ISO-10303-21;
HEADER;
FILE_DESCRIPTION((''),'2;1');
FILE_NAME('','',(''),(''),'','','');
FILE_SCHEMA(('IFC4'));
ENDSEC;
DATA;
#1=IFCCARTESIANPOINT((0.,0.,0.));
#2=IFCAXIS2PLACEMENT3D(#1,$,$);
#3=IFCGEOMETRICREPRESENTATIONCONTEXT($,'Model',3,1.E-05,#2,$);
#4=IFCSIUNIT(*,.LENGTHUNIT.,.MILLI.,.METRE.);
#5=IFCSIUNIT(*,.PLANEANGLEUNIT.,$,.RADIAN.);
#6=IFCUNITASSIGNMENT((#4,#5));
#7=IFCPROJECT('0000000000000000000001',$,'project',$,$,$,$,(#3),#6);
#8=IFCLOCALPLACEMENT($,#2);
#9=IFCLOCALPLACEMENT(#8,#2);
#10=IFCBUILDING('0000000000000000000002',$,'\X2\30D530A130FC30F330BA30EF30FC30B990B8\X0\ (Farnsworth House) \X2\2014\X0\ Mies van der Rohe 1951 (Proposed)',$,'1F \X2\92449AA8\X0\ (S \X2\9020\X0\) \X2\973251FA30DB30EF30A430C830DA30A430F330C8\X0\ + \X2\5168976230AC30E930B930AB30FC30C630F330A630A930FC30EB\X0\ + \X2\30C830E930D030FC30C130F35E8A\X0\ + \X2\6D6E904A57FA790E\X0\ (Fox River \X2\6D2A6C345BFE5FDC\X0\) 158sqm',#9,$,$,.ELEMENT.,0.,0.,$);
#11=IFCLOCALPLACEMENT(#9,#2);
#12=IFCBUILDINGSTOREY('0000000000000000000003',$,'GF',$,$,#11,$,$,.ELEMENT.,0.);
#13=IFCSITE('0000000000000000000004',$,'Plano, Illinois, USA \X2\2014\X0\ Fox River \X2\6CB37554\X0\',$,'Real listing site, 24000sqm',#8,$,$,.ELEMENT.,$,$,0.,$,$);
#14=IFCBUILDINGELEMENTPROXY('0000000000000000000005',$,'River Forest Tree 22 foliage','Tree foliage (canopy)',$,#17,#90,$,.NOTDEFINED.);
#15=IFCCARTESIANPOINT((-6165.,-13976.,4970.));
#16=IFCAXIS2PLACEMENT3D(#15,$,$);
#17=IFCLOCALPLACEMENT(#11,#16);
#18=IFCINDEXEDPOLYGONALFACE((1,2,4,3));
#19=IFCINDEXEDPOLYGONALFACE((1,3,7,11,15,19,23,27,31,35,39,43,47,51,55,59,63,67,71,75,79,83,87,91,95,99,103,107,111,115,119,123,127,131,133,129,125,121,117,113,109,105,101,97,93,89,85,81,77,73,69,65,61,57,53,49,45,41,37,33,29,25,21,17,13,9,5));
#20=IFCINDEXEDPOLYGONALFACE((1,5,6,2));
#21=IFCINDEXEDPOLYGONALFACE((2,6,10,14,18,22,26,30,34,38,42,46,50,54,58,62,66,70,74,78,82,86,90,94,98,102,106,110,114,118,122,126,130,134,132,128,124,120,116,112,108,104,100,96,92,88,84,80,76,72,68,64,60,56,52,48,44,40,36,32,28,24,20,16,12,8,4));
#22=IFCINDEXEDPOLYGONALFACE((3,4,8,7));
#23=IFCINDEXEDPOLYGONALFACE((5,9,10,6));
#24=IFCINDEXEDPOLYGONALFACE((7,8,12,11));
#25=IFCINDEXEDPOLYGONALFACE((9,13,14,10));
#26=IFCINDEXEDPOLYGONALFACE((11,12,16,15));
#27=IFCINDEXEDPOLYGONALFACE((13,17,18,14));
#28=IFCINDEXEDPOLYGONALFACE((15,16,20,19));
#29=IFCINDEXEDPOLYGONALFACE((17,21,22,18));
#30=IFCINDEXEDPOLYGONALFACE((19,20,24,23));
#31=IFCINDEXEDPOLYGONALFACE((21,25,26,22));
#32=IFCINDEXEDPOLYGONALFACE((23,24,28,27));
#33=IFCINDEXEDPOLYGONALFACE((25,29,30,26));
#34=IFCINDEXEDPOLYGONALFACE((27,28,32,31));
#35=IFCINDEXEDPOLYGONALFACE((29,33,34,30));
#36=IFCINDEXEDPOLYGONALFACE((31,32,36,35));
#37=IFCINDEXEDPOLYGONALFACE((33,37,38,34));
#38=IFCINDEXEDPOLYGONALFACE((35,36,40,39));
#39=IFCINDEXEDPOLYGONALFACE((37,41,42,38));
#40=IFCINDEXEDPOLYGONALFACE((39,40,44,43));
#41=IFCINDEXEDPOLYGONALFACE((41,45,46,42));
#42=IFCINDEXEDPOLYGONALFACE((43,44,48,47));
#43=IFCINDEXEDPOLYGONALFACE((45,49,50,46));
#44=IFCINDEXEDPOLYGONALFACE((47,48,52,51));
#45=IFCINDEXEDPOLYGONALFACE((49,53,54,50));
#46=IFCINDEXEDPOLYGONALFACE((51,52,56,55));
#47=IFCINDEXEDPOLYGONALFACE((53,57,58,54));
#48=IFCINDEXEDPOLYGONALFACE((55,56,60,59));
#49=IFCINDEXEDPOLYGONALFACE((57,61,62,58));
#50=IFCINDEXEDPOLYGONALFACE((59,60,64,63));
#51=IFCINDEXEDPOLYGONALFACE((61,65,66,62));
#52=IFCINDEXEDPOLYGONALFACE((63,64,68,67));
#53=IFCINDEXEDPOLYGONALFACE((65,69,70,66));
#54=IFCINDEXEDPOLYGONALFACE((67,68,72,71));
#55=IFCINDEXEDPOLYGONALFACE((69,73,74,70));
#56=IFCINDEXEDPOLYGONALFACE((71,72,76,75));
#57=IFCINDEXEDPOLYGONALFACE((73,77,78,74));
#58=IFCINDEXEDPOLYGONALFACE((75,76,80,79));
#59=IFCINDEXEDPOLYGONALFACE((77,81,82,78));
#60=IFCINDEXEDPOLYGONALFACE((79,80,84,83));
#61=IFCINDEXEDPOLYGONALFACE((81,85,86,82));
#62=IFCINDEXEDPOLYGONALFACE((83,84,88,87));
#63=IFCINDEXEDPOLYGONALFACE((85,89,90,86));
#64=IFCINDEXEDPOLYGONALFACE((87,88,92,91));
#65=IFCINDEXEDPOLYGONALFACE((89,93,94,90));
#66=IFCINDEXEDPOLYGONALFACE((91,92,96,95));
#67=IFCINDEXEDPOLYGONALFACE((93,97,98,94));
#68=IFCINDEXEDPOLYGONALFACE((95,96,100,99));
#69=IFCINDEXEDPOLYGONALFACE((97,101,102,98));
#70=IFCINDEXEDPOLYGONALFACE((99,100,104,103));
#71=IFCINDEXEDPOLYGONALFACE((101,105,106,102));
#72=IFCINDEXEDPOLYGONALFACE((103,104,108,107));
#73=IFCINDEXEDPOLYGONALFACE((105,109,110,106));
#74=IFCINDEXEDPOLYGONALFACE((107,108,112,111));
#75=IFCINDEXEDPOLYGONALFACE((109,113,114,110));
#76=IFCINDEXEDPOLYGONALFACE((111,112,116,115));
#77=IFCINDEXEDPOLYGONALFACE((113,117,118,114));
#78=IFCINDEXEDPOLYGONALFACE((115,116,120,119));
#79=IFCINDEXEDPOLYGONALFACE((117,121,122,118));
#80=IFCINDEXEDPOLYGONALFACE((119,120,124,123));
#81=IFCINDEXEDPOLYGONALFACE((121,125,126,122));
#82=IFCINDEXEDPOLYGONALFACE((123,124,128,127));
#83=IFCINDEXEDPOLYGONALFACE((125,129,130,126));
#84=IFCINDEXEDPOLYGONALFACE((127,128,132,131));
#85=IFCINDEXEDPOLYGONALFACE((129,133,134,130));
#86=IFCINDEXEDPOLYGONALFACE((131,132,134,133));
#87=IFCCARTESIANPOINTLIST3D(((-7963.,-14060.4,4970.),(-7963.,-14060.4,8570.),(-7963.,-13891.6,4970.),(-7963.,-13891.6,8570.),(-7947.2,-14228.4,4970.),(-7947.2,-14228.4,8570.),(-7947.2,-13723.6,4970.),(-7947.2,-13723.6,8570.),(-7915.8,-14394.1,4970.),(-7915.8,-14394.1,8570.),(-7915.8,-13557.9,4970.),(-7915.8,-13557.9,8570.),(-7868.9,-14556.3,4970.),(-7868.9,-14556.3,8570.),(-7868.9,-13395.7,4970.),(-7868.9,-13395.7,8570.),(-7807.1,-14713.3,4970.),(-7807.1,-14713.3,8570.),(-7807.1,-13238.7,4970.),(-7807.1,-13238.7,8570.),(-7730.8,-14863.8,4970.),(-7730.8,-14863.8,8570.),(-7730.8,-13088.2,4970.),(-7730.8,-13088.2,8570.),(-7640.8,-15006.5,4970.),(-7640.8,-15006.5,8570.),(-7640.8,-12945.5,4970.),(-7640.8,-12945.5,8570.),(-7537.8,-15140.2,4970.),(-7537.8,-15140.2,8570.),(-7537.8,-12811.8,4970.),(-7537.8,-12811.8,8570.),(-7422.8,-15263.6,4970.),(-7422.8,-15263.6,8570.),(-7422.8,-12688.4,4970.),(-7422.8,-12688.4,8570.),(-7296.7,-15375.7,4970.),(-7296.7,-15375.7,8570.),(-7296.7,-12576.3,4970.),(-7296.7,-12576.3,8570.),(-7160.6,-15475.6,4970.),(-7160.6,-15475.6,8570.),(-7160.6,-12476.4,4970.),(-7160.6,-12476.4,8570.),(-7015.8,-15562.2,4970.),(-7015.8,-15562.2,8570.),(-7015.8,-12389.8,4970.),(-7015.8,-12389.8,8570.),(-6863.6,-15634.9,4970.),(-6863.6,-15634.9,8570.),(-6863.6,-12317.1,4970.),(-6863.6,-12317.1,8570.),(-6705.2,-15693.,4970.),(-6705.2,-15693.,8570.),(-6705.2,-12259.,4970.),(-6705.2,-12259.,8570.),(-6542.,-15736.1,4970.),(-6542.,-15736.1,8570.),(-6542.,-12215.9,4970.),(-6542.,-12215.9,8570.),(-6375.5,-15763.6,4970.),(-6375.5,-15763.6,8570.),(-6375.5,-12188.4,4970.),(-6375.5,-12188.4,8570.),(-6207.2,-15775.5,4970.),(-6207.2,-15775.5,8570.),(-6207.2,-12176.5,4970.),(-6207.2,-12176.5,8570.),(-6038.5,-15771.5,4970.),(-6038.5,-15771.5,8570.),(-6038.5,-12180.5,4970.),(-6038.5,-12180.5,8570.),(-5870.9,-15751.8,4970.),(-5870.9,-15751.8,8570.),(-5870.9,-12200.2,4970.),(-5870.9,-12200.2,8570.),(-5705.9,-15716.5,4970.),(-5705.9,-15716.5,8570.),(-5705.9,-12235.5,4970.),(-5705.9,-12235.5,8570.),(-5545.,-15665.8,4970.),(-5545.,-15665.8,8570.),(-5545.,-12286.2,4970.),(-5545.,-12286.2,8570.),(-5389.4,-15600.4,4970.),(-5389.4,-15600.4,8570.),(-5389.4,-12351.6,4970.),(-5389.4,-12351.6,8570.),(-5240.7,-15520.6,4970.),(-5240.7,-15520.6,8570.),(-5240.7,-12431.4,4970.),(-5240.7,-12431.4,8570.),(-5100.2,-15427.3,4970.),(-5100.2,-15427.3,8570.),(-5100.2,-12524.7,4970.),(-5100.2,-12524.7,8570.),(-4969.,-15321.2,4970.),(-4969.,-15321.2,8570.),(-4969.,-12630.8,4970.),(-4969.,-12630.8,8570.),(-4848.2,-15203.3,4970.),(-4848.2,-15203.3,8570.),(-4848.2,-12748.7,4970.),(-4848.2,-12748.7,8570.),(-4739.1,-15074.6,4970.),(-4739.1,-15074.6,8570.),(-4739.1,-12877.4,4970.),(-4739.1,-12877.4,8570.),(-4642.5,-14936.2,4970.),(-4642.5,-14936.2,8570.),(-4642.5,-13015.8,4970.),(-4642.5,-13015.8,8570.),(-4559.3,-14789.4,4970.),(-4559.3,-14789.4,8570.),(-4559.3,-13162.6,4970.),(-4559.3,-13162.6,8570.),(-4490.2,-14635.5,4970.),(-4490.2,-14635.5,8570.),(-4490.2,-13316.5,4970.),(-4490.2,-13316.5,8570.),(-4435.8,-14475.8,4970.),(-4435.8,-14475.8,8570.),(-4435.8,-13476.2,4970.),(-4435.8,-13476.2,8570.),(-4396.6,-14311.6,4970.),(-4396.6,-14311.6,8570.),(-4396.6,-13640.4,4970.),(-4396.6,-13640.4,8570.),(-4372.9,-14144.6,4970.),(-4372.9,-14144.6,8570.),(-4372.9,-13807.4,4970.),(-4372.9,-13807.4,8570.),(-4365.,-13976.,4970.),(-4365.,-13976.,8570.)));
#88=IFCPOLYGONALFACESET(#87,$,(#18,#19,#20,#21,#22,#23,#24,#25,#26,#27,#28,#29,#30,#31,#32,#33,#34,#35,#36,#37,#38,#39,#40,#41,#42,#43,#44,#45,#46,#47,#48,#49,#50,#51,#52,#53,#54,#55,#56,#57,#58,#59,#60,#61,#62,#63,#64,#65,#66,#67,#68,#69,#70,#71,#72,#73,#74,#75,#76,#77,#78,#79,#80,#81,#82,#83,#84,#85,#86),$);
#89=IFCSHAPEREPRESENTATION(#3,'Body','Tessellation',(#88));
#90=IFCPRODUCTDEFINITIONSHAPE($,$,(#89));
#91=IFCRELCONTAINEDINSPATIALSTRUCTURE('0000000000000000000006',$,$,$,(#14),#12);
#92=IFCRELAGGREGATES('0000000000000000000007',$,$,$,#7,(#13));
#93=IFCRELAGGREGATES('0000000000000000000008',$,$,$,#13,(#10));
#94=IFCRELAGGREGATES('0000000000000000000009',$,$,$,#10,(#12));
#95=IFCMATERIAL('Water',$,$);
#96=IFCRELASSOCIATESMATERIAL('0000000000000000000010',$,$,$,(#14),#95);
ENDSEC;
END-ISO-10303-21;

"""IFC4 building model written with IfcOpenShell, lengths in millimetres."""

from ifc_helpers import new_model, si_unit, frame, origin, origin_2d, place, context, project, spatial, circle, extrude, material, element, save


model = new_model("IFC4")

# Units and contexts
model_context = context("Model", 3, precision=1e-05, world=origin())
ifc_project = project(units=[si_unit("LENGTHUNIT", "METRE", prefix="MILLI"), si_unit("PLANEANGLEUNIT", "RADIAN")], contexts=[model_context])

# Site, building, storey
site_placement = place(None, origin())
site = spatial("IfcSite", under=ifc_project, at=site_placement, Name="Plano, Illinois, USA — Fox River 河畔", ObjectType="Real listing site, 24000sqm", CompositionType="ELEMENT", RefElevation=0.0)
building_placement = place(site_placement, origin())
building = spatial("IfcBuilding", under=site, at=building_placement, Name="ファーンズワース邸 (Farnsworth House) — Mies van der Rohe 1951 (Proposed)", ObjectType="1F 鉄骨 (S 造) 露出ホワイトペイント + 全面ガラスカーテンウォール + トラバーチン床 + 浮遊基礎 (Fox River 洪水対応) 158sqm", CompositionType="ELEMENT", ElevationOfRefHeight=0.0, ElevationOfTerrain=0.0)
storey_placement = place(building_placement, origin())
storey = spatial("IfcBuildingStorey", under=building, at=storey_placement, Name="GF", CompositionType="ELEMENT", Elevation=0.0)

# Building element proxy
ifc_material_1 = material(Name="Water")
proxy_1_placement = place(storey_placement, frame((-6165.0, -13976.0, 4970.0)))
element("IfcBuildingElementProxy", 1, at=proxy_1_placement, inside=storey, material=ifc_material_1, Name="River Forest Tree 22 foliage", Description="Tree foliage (canopy)", PredefinedType="NOTDEFINED", context=model_context, shape_type="SweptSolid", body=[
    extrude(circle(Radius=1800.0, at=origin_2d()), frame((-6165.0, -13976.0, 4970.0)), (0.0, 0.0, 1.0), 3600.0),
])

save(model, "model.ifc")
